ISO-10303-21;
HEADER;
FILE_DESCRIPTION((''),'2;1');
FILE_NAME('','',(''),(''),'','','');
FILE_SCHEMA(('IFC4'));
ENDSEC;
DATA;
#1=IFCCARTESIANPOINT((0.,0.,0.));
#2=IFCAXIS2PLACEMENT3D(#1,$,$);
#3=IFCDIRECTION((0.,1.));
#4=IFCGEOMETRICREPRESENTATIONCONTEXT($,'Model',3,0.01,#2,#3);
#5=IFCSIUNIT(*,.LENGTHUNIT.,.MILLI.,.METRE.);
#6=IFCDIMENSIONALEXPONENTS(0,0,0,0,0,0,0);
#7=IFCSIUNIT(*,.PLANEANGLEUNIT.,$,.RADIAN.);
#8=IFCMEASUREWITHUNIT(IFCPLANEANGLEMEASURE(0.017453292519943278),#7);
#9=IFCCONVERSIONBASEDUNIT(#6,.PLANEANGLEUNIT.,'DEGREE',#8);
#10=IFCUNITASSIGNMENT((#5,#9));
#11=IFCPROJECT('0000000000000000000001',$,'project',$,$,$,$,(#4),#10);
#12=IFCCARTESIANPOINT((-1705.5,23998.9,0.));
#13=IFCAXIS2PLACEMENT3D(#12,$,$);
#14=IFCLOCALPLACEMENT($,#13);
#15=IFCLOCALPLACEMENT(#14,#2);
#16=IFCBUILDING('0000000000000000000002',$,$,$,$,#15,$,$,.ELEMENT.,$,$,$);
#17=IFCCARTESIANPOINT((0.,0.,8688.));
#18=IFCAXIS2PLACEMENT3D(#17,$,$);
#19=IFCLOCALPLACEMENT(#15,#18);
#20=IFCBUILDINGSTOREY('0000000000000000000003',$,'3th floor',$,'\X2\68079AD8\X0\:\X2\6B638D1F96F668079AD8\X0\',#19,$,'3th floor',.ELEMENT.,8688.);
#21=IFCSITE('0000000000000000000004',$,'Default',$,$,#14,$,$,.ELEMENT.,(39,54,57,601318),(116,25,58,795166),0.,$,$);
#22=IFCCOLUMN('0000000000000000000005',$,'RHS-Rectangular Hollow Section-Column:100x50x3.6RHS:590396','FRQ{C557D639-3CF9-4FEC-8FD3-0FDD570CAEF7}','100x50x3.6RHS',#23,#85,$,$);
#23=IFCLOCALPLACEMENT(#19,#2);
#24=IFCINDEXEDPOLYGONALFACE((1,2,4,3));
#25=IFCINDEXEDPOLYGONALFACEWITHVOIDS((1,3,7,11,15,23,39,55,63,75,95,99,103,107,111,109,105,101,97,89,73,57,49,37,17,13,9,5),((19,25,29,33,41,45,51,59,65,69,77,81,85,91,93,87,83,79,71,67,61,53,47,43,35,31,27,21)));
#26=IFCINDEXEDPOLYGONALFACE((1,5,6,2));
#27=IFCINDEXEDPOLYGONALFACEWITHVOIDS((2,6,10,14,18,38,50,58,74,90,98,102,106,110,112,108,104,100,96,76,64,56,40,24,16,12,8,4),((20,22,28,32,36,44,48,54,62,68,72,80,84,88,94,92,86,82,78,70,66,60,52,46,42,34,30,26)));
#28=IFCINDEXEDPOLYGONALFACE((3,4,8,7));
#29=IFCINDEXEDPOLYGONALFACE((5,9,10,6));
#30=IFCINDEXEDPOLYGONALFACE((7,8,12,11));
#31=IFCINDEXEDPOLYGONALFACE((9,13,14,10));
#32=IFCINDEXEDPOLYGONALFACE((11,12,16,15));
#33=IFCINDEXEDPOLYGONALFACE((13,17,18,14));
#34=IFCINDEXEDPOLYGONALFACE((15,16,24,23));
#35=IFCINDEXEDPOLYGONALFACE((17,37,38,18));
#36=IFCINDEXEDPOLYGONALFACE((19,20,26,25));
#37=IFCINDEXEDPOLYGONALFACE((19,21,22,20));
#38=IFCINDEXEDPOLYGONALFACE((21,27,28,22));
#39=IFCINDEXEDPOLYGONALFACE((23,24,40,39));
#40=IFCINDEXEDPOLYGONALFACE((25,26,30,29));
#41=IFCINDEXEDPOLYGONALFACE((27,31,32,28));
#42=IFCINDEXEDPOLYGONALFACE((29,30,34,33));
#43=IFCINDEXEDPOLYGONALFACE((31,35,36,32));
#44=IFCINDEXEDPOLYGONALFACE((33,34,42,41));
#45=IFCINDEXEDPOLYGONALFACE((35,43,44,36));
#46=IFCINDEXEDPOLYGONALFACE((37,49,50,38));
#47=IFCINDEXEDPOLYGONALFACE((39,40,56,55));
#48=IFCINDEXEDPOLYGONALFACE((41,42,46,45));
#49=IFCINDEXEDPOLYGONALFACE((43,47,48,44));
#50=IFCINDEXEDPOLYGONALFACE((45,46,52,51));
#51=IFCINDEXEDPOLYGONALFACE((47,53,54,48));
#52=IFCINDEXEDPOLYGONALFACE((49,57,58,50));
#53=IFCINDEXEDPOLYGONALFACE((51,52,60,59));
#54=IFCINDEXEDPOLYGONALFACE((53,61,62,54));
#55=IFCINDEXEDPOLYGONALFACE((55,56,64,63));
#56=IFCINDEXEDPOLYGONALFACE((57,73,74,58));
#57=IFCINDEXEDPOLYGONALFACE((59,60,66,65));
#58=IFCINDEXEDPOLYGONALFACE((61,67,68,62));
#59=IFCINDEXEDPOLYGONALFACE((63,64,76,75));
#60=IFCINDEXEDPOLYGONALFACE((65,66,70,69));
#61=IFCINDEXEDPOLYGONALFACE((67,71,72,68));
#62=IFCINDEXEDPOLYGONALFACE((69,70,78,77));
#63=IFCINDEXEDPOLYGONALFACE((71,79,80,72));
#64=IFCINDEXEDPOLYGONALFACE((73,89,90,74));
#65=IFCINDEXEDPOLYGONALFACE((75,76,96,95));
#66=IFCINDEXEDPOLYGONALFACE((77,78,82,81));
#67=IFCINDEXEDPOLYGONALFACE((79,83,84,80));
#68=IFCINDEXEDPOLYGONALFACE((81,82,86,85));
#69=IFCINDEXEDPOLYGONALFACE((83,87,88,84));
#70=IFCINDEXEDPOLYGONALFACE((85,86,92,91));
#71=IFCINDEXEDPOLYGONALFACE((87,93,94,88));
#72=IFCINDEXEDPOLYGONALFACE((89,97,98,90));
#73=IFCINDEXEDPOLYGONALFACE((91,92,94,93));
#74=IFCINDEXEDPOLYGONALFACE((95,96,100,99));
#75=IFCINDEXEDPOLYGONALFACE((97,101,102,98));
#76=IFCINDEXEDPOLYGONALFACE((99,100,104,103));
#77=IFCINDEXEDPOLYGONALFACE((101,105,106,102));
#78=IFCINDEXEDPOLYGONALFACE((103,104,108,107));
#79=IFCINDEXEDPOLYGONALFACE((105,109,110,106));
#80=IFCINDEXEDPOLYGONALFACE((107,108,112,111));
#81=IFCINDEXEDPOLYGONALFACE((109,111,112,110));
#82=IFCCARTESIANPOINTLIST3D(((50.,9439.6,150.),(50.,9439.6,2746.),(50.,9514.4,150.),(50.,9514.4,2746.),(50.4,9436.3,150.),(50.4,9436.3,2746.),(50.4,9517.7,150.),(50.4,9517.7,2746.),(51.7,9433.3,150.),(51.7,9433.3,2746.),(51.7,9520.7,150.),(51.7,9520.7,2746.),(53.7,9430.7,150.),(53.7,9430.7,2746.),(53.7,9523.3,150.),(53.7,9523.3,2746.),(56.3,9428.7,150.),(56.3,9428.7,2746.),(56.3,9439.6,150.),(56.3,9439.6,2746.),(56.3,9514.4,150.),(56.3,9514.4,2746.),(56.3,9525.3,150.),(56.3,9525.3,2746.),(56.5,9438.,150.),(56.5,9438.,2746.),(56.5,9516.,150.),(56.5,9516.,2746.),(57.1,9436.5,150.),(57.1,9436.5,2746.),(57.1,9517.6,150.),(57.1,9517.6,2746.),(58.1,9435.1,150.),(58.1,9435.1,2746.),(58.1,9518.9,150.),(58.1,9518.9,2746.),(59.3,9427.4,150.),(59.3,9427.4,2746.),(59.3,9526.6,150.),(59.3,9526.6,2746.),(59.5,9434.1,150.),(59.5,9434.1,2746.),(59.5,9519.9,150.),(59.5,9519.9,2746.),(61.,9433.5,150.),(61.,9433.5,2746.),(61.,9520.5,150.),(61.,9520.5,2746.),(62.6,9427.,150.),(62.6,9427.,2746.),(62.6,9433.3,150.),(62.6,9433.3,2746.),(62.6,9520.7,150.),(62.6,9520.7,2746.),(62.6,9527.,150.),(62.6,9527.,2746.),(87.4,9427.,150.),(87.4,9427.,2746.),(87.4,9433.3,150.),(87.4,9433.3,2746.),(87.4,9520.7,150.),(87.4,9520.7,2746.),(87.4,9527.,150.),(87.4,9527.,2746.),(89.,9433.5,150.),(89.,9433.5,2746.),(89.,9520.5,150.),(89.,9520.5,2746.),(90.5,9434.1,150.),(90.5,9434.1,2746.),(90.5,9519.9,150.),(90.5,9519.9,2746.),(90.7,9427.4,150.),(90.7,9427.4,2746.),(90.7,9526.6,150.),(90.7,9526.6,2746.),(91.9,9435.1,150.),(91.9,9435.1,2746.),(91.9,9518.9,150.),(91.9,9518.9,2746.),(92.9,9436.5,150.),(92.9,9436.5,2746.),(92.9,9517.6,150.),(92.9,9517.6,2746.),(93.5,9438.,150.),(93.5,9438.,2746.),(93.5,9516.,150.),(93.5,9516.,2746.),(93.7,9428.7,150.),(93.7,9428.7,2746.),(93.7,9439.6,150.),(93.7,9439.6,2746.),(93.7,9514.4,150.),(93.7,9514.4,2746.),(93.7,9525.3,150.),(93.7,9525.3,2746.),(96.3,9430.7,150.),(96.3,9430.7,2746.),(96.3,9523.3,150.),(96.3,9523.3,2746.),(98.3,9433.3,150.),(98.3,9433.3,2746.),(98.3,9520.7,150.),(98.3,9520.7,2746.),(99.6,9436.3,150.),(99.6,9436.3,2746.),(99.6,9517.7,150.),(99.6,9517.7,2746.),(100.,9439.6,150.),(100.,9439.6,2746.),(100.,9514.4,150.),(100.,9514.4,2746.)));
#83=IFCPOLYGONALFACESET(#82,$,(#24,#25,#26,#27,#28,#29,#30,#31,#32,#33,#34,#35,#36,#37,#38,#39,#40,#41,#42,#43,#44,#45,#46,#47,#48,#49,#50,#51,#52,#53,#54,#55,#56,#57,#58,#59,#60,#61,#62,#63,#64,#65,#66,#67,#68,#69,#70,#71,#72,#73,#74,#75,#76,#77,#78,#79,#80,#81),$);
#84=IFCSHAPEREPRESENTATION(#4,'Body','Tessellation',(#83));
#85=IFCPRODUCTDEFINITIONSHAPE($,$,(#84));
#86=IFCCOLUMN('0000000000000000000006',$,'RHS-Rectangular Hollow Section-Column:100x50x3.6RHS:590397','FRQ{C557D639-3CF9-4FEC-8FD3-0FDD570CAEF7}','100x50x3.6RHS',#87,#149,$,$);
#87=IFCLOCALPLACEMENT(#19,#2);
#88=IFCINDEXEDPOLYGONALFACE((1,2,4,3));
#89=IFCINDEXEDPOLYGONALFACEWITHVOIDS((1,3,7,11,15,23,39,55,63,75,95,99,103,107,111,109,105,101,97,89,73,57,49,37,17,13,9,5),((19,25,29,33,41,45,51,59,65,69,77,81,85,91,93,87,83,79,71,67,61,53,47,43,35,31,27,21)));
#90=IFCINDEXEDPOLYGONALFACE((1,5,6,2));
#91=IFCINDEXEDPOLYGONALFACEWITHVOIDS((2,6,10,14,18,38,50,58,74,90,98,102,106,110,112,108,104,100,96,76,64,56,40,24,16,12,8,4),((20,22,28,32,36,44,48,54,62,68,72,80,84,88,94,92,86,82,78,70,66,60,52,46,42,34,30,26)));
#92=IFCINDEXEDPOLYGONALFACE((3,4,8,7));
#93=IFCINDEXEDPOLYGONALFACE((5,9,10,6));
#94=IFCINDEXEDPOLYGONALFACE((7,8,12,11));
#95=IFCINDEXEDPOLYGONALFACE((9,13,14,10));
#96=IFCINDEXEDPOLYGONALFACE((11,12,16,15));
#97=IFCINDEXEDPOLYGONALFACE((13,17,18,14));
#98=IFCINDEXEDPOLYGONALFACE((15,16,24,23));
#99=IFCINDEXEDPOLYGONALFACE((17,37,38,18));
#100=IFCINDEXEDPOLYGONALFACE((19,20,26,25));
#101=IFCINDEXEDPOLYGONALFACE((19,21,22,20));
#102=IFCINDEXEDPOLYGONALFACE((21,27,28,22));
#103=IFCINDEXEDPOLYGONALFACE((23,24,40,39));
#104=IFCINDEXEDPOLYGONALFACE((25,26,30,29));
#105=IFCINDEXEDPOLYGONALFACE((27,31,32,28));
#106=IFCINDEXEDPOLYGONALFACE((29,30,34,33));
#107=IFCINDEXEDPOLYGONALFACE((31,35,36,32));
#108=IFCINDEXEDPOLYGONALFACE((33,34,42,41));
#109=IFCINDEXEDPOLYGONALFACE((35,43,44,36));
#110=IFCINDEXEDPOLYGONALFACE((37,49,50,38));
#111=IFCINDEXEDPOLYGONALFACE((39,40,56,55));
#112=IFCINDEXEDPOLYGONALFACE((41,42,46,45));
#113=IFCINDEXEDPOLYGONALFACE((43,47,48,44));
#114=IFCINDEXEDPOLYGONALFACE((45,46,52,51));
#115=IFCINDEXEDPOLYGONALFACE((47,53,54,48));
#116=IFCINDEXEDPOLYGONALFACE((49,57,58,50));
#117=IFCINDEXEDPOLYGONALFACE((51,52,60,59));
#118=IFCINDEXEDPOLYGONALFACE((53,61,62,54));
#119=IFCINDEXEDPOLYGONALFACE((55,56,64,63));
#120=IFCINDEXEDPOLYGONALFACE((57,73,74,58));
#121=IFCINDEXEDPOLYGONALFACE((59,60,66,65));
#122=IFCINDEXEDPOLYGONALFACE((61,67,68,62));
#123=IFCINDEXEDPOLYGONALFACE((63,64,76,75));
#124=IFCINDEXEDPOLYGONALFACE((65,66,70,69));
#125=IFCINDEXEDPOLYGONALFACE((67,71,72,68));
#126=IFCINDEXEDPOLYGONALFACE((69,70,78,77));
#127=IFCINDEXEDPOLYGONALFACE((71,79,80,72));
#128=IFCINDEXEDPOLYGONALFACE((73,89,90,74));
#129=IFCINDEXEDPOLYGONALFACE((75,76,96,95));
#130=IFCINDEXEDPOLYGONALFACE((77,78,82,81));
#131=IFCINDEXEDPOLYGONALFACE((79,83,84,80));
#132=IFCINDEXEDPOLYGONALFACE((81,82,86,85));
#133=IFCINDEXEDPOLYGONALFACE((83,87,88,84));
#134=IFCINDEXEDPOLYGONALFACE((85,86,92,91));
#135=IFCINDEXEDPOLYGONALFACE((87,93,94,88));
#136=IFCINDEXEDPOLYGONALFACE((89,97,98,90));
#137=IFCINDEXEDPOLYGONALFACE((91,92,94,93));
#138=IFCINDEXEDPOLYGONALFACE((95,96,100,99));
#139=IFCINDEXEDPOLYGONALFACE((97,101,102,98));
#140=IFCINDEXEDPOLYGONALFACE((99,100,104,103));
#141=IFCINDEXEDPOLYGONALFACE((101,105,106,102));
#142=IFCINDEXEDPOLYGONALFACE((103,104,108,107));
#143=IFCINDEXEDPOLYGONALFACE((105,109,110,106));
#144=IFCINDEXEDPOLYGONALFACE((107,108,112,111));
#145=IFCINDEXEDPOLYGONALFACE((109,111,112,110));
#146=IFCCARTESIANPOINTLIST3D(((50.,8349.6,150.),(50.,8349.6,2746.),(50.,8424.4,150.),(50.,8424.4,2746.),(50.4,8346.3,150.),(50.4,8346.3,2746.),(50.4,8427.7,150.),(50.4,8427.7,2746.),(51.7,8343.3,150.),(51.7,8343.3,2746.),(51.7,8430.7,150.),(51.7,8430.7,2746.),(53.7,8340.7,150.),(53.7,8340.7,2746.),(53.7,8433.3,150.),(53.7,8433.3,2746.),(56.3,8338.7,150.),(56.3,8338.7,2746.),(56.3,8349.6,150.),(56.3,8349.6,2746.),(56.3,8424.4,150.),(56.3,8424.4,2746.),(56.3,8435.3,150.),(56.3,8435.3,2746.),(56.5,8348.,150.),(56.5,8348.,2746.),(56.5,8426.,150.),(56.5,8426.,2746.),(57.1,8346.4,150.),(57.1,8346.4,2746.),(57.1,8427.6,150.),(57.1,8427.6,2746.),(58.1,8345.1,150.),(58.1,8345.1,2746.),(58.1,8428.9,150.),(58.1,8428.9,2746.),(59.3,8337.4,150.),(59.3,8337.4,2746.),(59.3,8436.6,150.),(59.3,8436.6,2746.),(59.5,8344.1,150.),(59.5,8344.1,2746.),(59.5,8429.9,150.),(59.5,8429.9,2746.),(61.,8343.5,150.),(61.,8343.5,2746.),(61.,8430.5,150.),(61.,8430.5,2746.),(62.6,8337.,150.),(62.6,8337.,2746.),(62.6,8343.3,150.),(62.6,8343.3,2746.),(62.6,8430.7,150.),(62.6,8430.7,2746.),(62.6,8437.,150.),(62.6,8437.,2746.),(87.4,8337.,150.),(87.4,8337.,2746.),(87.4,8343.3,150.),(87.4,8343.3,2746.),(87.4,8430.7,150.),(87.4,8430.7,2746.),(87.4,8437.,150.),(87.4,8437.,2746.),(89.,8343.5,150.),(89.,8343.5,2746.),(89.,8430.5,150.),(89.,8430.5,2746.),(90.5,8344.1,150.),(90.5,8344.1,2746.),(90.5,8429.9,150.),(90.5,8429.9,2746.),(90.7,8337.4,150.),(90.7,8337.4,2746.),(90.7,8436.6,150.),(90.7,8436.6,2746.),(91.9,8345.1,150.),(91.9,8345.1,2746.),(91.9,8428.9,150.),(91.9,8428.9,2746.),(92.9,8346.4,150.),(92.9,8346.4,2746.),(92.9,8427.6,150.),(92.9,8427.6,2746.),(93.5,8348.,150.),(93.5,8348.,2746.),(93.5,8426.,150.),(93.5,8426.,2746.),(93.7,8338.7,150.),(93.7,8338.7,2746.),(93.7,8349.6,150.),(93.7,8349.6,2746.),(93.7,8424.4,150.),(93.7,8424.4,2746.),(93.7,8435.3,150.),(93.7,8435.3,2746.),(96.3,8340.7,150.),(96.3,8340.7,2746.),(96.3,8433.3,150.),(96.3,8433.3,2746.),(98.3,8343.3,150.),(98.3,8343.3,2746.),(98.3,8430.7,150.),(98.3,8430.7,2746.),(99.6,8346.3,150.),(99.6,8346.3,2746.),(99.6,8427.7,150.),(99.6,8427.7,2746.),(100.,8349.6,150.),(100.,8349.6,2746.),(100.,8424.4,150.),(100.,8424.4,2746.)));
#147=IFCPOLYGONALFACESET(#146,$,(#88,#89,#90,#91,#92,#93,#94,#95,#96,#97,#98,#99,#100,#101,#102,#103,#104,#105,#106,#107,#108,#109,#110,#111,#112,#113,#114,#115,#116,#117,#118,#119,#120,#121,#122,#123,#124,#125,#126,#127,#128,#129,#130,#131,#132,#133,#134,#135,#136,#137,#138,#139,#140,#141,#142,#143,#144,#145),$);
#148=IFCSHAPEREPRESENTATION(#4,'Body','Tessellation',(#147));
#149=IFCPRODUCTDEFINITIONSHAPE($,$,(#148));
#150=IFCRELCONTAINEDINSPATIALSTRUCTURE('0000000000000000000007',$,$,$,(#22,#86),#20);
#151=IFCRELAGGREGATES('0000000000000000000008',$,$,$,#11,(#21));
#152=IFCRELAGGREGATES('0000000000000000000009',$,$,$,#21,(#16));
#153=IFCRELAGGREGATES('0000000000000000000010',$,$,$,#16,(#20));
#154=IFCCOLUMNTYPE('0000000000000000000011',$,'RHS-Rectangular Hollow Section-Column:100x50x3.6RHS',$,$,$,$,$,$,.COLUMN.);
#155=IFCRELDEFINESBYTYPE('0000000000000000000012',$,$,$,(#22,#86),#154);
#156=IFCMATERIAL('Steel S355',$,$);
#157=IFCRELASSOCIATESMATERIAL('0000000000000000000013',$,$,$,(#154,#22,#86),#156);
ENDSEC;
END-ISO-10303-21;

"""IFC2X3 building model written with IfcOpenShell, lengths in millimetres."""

from ifc_helpers import new_model, entity, si_unit, converted_unit, point, direction, frame, frame_2d, origin, origin_2d, place, context, project, spatial, circle_curve, line_curve, trimmed, segment, composite_curve, hollow_rectangle, outline, extrude, clip, halfspace, material, type_object, element, save


model = new_model("IFC2X3")

# Units and contexts
model_context = context("Model", 3, precision=0.01, world=origin(), true_north=direction((0.0, 1.0)))
ifc_project = project(units=[si_unit("LENGTHUNIT", "METRE", prefix="MILLI"), converted_unit("PLANEANGLEUNIT", "DEGREE", entity("IfcPlaneAngleMeasure", 0.017453292519943278), si_unit("PLANEANGLEUNIT", "RADIAN"), dimensions=[0, 0, 0, 0, 0, 0, 0])], contexts=[model_context])

# Site, building, storey
site_placement = place(None, frame((-1705.5, 23998.9, 0.0)))
site = spatial("IfcSite", under=ifc_project, at=site_placement, Name="Default", CompositionType="ELEMENT", RefLatitude=(39, 54, 57, 601318), RefLongitude=(116, 25, 58, 795166), RefElevation=0.0)
building_placement = place(site_placement, origin())
building = spatial("IfcBuilding", under=site, at=building_placement, CompositionType="ELEMENT")
storey_placement = place(building_placement, frame((0.0, 0.0, 8688.0)))
storey = spatial("IfcBuildingStorey", under=building, at=storey_placement, Name="3th floor", ObjectType="标高:正负零标高", LongName="3th floor", CompositionType="ELEMENT", Elevation=8688.0)

# Shared definitions
ifc_material_1 = material(Name="Steel S355")

# Columns, openings
column_type_1 = type_object("IfcColumnType", Name="RHS-Rectangular Hollow Section-Column:100x50x3.6RHS", PredefinedType="COLUMN", material=ifc_material_1)
column_1_placement = place(storey_placement, frame((75.0, 9477.0, 2876.9)))
column_1 = element("IfcColumn", 1, at=column_1_placement, inside=storey, type_object=column_type_1, material=ifc_material_1, Name="RHS-Rectangular Hollow Section-Column:100x50x3.6RHS:590396", Description="FRQ{C557D639-3CF9-4FEC-8FD3-0FDD570CAEF7}", ObjectType="100x50x3.6RHS", context=model_context, shape_type="Clipping", body=[
    clip(clip(extrude(hollow_rectangle(XDim=50.0, YDim=100.0, WallThickness=6.3, InnerFilletRadius=6.3, OuterFilletRadius=12.6, at=origin_2d()), origin(), (0.0, 0.0, -1.0), 2782.8), halfspace(frame((-75.0, -9477.0, -55.9), z_axis=(0.0, 0.0, -1.0), x_axis=(-1.0, 0.0, 0.0)), True)), halfspace(frame((-75.0, -9477.0, -2726.9), z_axis=(0.0, 0.0, 1.0), x_axis=(1.0, 0.0, 0.0)), True)),
])
opening_1_placement = place(column_1_placement, frame((0.0, -150.1, -130.9), z_axis=(0.0, 1.0, 0.0), x_axis=(-1.0, 0.0, 0.0)))
element("IfcOpeningElement", 2, at=opening_1_placement, cuts=column_1, ObjectType="Opening", context=model_context, shape_type="SweptSolid", body=[
    extrude(outline(composite_curve([segment(trimmed(circle_curve(frame_2d((43.0, 32.0), x_axis=(1.0, 0.0)), 32.0), [point((43.0, 0.0))], [point((75.0, 32.0))], True, "CARTESIAN"), True, "CONTINUOUS"), segment(trimmed(line_curve((75.0, 32.0), (0.0, 1.0), 86.0), [point((75.0, 32.0))], [point((75.0, 118.0))], True, "CARTESIAN"), True, "CONTINUOUS"), segment(trimmed(circle_curve(frame_2d((43.0, 118.0), x_axis=(1.0, 0.0)), 32.0), [point((75.0, 118.0))], [point((43.0, 150.0))], True, "CARTESIAN"), True, "CONTINUOUS"), segment(trimmed(line_curve((43.0, 150.0), (-1.0, 0.0), 86.0), [point((43.0, 150.0))], [point((-43.0, 150.0))], True, "CARTESIAN"), True, "CONTINUOUS"), segment(trimmed(circle_curve(frame_2d((-43.0, 118.0), x_axis=(1.0, 0.0)), 32.0), [point((-43.0, 150.0))], [point((-75.0, 118.0))], True, "CARTESIAN"), True, "CONTINUOUS"), segment(trimmed(line_curve((-75.0, 118.0), (0.0, -1.0), 86.0), [point((-75.0, 118.0))], [point((-75.0, 32.0))], True, "CARTESIAN"), True, "CONTINUOUS"), segment(trimmed(circle_curve(frame_2d((-43.0, 32.0), x_axis=(1.0, 0.0)), 32.0), [point((-75.0, 32.0))], [point((-43.0, 0.0))], True, "CARTESIAN"), True, "CONTINUOUS"), segment(trimmed(line_curve((-43.0, 0.0), (1.0, 0.0), 86.0), [point((-43.0, 0.0))], [point((43.0, 0.0))], True, "CARTESIAN"), True, "CONTINUOUS")], self_intersect="UNKNOWN")), origin(), (0.0, 0.0, 1.0), 300.2),
])
column_2_placement = place(storey_placement, frame((75.0, 8387.0, 2876.9)))
column_2 = element("IfcColumn", 3, at=column_2_placement, inside=storey, type_object=column_type_1, material=ifc_material_1, Name="RHS-Rectangular Hollow Section-Column:100x50x3.6RHS:590397", Description="FRQ{C557D639-3CF9-4FEC-8FD3-0FDD570CAEF7}", ObjectType="100x50x3.6RHS", context=model_context, shape_type="Clipping", body=[
    clip(clip(extrude(hollow_rectangle(XDim=50.0, YDim=100.0, WallThickness=6.3, InnerFilletRadius=6.3, OuterFilletRadius=12.6, at=origin_2d()), origin(), (0.0, 0.0, -1.0), 2782.8), halfspace(frame((-75.0, -8387.0, -2726.9), z_axis=(0.0, 0.0, 1.0), x_axis=(1.0, 0.0, 0.0)), True)), halfspace(frame((-75.0, -8387.0, -55.9), z_axis=(0.0, 0.0, -1.0), x_axis=(-1.0, 0.0, 0.0)), True)),
])
opening_2_placement = place(column_2_placement, frame((0.0, -150.1, -130.9), z_axis=(0.0, 1.0, 0.0), x_axis=(-1.0, 0.0, 0.0)))
element("IfcOpeningElement", 4, at=opening_2_placement, cuts=column_2, ObjectType="Opening", context=model_context, shape_type="SweptSolid", body=[
    extrude(outline(composite_curve([segment(trimmed(circle_curve(frame_2d((43.0, 32.0), x_axis=(1.0, 0.0)), 32.0), [point((43.0, 0.0))], [point((75.0, 32.0))], True, "CARTESIAN"), True, "CONTINUOUS"), segment(trimmed(line_curve((75.0, 32.0), (0.0, 1.0), 86.0), [point((75.0, 32.0))], [point((75.0, 118.0))], True, "CARTESIAN"), True, "CONTINUOUS"), segment(trimmed(circle_curve(frame_2d((43.0, 118.0), x_axis=(1.0, 0.0)), 32.0), [point((75.0, 118.0))], [point((43.0, 150.0))], True, "CARTESIAN"), True, "CONTINUOUS"), segment(trimmed(line_curve((43.0, 150.0), (-1.0, 0.0), 86.0), [point((43.0, 150.0))], [point((-43.0, 150.0))], True, "CARTESIAN"), True, "CONTINUOUS"), segment(trimmed(circle_curve(frame_2d((-43.0, 118.0), x_axis=(1.0, 0.0)), 32.0), [point((-43.0, 150.0))], [point((-75.0, 118.0))], True, "CARTESIAN"), True, "CONTINUOUS"), segment(trimmed(line_curve((-75.0, 118.0), (0.0, -1.0), 86.0), [point((-75.0, 118.0))], [point((-75.0, 32.0))], True, "CARTESIAN"), True, "CONTINUOUS"), segment(trimmed(circle_curve(frame_2d((-43.0, 32.0), x_axis=(1.0, 0.0)), 32.0), [point((-75.0, 32.0))], [point((-43.0, 0.0))], True, "CARTESIAN"), True, "CONTINUOUS"), segment(trimmed(line_curve((-43.0, 0.0), (1.0, 0.0), 86.0), [point((-43.0, 0.0))], [point((43.0, 0.0))], True, "CARTESIAN"), True, "CONTINUOUS")], self_intersect="UNKNOWN")), origin(), (0.0, 0.0, 1.0), 300.2),
])

save(model, "model.ifc")
